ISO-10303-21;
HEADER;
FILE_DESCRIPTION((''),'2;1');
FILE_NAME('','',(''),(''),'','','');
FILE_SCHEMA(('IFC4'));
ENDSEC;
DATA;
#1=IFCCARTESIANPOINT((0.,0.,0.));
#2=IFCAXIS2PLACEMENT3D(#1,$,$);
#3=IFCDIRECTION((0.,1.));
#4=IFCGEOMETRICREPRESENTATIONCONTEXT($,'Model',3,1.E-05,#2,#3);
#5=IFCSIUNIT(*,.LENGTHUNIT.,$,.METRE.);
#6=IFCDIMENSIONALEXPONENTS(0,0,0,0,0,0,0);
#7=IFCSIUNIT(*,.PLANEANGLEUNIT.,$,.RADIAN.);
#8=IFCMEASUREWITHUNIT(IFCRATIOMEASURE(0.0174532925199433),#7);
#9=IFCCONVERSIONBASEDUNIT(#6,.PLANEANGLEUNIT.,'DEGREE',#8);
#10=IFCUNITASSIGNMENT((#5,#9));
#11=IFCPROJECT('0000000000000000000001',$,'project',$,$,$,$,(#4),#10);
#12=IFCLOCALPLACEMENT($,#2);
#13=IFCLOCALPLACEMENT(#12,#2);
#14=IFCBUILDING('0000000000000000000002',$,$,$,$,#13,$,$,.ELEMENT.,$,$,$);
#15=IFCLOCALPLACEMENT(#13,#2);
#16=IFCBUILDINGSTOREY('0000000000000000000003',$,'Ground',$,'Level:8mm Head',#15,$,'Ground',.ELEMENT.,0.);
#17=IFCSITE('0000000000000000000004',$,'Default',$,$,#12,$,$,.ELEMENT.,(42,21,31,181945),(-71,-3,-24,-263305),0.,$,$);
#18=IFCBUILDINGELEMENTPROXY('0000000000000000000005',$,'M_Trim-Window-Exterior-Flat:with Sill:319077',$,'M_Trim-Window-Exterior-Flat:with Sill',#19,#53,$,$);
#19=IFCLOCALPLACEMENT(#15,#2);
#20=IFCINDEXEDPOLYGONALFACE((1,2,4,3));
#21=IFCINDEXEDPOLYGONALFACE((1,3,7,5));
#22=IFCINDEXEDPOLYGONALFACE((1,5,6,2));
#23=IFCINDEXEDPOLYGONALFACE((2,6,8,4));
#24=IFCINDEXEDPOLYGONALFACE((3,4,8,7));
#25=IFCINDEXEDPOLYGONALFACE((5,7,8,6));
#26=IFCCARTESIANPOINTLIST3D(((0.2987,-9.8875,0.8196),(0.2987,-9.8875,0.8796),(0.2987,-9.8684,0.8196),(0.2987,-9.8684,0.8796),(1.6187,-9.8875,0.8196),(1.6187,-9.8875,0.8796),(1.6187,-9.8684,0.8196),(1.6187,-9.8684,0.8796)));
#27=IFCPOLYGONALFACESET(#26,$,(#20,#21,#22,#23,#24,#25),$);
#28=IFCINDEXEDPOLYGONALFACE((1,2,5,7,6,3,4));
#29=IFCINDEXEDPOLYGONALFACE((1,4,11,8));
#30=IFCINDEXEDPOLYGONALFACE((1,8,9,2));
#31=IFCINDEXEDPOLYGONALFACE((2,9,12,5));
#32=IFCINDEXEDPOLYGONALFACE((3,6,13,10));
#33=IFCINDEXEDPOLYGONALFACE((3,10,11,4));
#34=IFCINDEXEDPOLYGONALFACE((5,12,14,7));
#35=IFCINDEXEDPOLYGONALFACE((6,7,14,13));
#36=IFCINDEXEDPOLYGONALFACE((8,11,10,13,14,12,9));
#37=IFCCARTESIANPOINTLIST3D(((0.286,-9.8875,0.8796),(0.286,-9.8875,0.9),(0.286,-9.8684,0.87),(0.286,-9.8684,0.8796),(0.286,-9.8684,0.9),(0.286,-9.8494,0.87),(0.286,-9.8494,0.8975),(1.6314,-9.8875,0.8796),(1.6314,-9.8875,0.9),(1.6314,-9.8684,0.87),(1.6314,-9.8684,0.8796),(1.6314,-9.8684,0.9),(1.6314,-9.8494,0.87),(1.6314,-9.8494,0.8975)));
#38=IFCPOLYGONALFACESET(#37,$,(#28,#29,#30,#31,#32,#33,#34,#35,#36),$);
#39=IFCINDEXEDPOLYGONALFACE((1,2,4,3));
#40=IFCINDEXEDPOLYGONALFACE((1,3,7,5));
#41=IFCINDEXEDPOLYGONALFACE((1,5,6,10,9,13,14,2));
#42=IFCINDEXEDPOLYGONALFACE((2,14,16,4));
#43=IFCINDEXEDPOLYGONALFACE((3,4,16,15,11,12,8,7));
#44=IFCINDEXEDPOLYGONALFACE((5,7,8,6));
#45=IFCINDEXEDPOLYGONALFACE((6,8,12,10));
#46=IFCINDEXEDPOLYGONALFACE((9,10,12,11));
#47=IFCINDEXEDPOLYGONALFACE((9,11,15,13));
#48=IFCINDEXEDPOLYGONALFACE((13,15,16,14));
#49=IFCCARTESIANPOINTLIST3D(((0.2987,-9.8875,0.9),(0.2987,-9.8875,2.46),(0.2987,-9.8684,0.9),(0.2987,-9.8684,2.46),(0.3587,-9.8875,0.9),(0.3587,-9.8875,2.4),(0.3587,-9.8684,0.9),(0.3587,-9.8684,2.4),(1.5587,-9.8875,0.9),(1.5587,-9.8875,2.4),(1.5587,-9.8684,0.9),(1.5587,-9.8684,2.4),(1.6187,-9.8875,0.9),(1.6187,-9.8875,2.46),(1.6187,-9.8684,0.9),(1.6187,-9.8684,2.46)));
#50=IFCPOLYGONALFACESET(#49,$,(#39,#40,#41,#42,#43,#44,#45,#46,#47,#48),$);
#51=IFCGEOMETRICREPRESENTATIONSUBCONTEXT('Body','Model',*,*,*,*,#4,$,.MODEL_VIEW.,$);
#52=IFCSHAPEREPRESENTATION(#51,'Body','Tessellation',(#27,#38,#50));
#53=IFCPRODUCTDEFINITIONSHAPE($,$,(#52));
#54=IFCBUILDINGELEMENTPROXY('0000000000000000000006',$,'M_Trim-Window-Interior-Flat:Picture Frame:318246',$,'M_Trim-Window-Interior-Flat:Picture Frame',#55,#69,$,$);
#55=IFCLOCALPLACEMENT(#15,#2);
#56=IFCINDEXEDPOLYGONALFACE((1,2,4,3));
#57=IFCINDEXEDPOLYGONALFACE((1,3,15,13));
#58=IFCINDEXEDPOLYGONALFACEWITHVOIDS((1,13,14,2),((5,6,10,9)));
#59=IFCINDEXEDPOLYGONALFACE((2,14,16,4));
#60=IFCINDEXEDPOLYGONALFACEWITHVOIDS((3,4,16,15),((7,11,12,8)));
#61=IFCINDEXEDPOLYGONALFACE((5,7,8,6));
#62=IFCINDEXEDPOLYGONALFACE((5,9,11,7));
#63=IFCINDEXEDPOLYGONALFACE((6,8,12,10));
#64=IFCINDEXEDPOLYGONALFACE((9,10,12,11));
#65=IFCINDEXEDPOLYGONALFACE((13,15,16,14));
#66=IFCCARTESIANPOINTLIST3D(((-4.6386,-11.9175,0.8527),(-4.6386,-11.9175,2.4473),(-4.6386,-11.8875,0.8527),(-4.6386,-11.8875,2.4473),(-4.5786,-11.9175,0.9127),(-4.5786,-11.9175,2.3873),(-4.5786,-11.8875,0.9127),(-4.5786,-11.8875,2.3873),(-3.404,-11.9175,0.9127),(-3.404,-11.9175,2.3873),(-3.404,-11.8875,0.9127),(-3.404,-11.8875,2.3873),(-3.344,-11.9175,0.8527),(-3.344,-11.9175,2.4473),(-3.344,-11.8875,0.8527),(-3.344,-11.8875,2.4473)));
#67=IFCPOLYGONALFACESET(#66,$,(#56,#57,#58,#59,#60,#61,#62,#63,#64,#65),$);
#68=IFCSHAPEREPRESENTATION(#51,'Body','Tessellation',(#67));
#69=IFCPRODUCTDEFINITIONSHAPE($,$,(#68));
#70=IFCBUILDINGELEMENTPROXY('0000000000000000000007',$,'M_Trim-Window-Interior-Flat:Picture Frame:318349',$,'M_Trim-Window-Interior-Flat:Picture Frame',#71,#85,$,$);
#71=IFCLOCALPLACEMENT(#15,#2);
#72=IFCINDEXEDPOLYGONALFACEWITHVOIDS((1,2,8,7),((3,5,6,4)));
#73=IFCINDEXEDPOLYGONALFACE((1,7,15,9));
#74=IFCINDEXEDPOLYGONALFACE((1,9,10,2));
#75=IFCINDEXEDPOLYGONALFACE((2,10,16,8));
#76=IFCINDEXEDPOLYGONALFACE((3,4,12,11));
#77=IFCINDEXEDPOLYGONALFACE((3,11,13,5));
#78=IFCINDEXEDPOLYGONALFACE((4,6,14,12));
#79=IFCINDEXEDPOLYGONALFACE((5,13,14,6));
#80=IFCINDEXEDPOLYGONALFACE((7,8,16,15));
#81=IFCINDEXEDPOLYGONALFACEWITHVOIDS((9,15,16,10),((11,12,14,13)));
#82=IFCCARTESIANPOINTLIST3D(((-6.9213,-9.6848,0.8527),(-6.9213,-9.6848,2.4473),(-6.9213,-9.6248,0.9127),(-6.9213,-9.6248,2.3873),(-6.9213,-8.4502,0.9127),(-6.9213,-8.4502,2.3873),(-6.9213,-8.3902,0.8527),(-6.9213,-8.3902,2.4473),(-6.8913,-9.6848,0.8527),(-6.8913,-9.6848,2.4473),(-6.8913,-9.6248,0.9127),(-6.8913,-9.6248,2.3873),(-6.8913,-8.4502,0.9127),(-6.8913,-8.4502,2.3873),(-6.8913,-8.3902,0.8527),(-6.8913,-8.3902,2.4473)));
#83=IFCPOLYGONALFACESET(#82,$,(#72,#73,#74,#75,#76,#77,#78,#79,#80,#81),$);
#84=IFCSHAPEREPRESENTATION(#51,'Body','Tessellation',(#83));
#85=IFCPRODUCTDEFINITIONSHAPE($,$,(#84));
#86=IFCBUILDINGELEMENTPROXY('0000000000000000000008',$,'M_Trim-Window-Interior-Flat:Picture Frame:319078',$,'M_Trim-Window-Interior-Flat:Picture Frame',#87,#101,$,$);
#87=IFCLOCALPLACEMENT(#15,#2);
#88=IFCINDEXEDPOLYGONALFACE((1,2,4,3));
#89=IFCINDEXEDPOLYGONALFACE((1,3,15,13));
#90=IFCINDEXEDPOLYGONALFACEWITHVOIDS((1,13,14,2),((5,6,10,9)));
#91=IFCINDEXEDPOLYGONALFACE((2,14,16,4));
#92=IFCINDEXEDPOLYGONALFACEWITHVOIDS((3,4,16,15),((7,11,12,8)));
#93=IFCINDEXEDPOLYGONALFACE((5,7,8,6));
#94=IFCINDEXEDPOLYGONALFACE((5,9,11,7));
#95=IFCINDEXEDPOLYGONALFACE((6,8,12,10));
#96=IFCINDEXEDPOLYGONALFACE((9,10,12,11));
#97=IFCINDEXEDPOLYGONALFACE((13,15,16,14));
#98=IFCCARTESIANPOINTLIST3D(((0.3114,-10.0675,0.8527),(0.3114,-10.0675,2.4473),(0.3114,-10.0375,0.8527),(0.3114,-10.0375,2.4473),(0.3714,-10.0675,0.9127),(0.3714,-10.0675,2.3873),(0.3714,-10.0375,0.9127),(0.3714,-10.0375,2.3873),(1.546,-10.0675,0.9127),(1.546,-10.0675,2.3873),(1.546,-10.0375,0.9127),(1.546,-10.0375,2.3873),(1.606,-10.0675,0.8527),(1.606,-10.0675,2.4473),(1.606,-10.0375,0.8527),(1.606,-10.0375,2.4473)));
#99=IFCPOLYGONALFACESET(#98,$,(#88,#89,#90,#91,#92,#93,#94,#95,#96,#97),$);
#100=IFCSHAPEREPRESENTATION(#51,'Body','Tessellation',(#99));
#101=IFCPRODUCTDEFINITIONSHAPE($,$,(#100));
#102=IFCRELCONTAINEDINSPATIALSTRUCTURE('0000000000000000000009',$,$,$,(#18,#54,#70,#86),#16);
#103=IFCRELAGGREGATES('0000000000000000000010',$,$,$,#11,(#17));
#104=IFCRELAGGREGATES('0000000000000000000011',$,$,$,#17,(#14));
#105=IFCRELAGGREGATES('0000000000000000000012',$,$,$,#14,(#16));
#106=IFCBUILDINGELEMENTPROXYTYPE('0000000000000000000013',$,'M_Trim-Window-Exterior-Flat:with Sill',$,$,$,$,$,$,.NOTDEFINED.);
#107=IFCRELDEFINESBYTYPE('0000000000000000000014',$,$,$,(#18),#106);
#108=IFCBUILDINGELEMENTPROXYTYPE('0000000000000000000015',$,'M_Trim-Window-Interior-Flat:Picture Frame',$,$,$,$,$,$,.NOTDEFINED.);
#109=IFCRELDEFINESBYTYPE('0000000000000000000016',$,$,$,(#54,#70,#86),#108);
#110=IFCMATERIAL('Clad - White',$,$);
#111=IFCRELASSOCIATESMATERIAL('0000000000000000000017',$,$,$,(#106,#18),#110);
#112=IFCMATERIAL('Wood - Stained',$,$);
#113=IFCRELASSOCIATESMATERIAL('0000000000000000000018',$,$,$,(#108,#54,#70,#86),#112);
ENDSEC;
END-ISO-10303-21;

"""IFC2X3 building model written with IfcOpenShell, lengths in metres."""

from ifc_helpers import new_model, entity, si_unit, converted_unit, direction, frame, frame_2d, origin, place, context, subcontext, project, spatial, polyline, rectangle, outline, extrude, source, transform, mapped, material, type_object, type_shapes, element, save


model = new_model("IFC2X3")

# Units and contexts
model_context = context("Model", 3, precision=1e-05, world=origin(), true_north=direction((0.0, 1.0)))
body_context = subcontext(model_context, "Body", "Model", "MODEL_VIEW")
ifc_project = project(units=[si_unit("LENGTHUNIT", "METRE"), converted_unit("PLANEANGLEUNIT", "DEGREE", entity("IfcRatioMeasure", 0.0174532925199433), si_unit("PLANEANGLEUNIT", "RADIAN"), dimensions=[0, 0, 0, 0, 0, 0, 0])], contexts=[model_context])

# Site, building, storey
site_placement = place(None, origin())
site = spatial("IfcSite", under=ifc_project, at=site_placement, Name="Default", CompositionType="ELEMENT", RefLatitude=(42, 21, 31, 181945), RefLongitude=(-71, -3, -24, -263305), RefElevation=0.0)
building_placement = place(site_placement, origin())
building = spatial("IfcBuilding", under=site, at=building_placement, CompositionType="ELEMENT")
storey_placement = place(building_placement, origin())
storey = spatial("IfcBuildingStorey", under=building, at=storey_placement, Name="Ground", ObjectType="Level:8mm Head", LongName="Ground", CompositionType="ELEMENT", Elevation=0.0)

# Building element proxies
ifc_material_1 = material(Name="Clad - White")
ifc_material_2 = material(Name="Wood - Stained")
building_element_proxy_type_1 = type_object("IfcBuildingElementProxyType", Name="M_Trim-Window-Exterior-Flat:with Sill", PredefinedType="NOTDEFINED", material=ifc_material_1)
shared_shape_1 = source(origin(), body_context, "Body", "SweptSolid", [
    extrude(rectangle(XDim=1.32, YDim=0.06, at=frame_2d((0.0, 0.0), x_axis=(1.0, 0.0))), frame((0.0, -1.5504, 0.0), z_axis=(0.0, 0.0, 1.0), x_axis=(-1.0, 0.0, 0.0)), (0.0, 0.0, 1.0), 0.0191),
    extrude(outline(polyline([(-0.019, -0.0152), (0.0, -0.0152), (0.0, -0.0057), (0.019, -0.0057), (0.019, 0.0148), (0.0, 0.0148), (-0.019, 0.0123), (-0.019, -0.0152)])), frame((-0.6727, -1.5148, 0.019), z_axis=(1.0, 0.0, 0.0), x_axis=(0.0, 0.0, -1.0)), (0.0, 0.0, 1.0), 1.3454),
    extrude(outline(polyline([(-0.795, -0.66), (0.765, -0.66), (0.765, -0.6), (-0.735, -0.6), (-0.735, 0.6), (0.765, 0.6), (0.765, 0.66), (-0.795, 0.66), (-0.795, -0.66)])), frame((0.0, -0.735, 0.0), z_axis=(0.0, 0.0, 1.0), x_axis=(0.0, -1.0, 0.0)), (0.0, 0.0, 1.0), 0.0191),
])
type_shapes(building_element_proxy_type_1, [shared_shape_1])
for number, where, z_axis, x_axis, name in (
    (1, (0.9587, -9.8875, 2.4), (0.0, 1.0, 0.0), (-1.0, 0.0, 0.0), "M_Trim-Window-Exterior-Flat:with Sill:319077"),
):
    element("IfcBuildingElementProxy", number, at=place(storey_placement, frame(where, z_axis=z_axis, x_axis=x_axis)), inside=storey, type_object=building_element_proxy_type_1, material=ifc_material_1, Name=name, ObjectType="M_Trim-Window-Exterior-Flat:with Sill", context=body_context, shape_type="MappedRepresentation", body=[
        mapped(shared_shape_1, transform((0.0, 0.0, 0.0), scale=1.0)),
    ])
building_element_proxy_type_2 = type_object("IfcBuildingElementProxyType", Name="M_Trim-Window-Interior-Flat:Picture Frame", PredefinedType="NOTDEFINED", material=ifc_material_2)
shared_shape_2 = source(origin(), body_context, "Body", "SweptSolid", [
    extrude(outline(polyline([(-0.6473, -0.7973), (0.6473, -0.7973), (0.6473, 0.7973), (-0.6473, 0.7973), (-0.6473, -0.7973)]), holes=[polyline([(-0.5873, -0.7373), (-0.5873, 0.7373), (0.5873, 0.7373), (0.5873, -0.7373), (-0.5873, -0.7373)])]), frame((0.0, -0.75, 0.0), z_axis=(0.0, 0.0, 1.0), x_axis=(-1.0, 0.0, 0.0)), (0.0, 0.0, 1.0), 0.03),
])
type_shapes(building_element_proxy_type_2, [shared_shape_2])
for number, where, z_axis, x_axis, name in (
    (2, (-3.9913, -11.8875, 2.4), (0.0, -1.0, 0.0), (1.0, 0.0, 0.0), "M_Trim-Window-Interior-Flat:Picture Frame:318246"),
    (3, (-6.8913, -9.0375, 2.4), (-1.0, 0.0, 0.0), (0.0, -1.0, 0.0), "M_Trim-Window-Interior-Flat:Picture Frame:318349"),
    (4, (0.9587, -10.0375, 2.4), (0.0, -1.0, 0.0), (1.0, 0.0, 0.0), "M_Trim-Window-Interior-Flat:Picture Frame:319078"),
):
    element("IfcBuildingElementProxy", number, at=place(storey_placement, frame(where, z_axis=z_axis, x_axis=x_axis)), inside=storey, type_object=building_element_proxy_type_2, material=ifc_material_2, Name=name, ObjectType="M_Trim-Window-Interior-Flat:Picture Frame", context=body_context, shape_type="MappedRepresentation", body=[
        mapped(shared_shape_2, transform((0.0, 0.0, 0.0), scale=1.0)),
    ])

save(model, "model.ifc")
